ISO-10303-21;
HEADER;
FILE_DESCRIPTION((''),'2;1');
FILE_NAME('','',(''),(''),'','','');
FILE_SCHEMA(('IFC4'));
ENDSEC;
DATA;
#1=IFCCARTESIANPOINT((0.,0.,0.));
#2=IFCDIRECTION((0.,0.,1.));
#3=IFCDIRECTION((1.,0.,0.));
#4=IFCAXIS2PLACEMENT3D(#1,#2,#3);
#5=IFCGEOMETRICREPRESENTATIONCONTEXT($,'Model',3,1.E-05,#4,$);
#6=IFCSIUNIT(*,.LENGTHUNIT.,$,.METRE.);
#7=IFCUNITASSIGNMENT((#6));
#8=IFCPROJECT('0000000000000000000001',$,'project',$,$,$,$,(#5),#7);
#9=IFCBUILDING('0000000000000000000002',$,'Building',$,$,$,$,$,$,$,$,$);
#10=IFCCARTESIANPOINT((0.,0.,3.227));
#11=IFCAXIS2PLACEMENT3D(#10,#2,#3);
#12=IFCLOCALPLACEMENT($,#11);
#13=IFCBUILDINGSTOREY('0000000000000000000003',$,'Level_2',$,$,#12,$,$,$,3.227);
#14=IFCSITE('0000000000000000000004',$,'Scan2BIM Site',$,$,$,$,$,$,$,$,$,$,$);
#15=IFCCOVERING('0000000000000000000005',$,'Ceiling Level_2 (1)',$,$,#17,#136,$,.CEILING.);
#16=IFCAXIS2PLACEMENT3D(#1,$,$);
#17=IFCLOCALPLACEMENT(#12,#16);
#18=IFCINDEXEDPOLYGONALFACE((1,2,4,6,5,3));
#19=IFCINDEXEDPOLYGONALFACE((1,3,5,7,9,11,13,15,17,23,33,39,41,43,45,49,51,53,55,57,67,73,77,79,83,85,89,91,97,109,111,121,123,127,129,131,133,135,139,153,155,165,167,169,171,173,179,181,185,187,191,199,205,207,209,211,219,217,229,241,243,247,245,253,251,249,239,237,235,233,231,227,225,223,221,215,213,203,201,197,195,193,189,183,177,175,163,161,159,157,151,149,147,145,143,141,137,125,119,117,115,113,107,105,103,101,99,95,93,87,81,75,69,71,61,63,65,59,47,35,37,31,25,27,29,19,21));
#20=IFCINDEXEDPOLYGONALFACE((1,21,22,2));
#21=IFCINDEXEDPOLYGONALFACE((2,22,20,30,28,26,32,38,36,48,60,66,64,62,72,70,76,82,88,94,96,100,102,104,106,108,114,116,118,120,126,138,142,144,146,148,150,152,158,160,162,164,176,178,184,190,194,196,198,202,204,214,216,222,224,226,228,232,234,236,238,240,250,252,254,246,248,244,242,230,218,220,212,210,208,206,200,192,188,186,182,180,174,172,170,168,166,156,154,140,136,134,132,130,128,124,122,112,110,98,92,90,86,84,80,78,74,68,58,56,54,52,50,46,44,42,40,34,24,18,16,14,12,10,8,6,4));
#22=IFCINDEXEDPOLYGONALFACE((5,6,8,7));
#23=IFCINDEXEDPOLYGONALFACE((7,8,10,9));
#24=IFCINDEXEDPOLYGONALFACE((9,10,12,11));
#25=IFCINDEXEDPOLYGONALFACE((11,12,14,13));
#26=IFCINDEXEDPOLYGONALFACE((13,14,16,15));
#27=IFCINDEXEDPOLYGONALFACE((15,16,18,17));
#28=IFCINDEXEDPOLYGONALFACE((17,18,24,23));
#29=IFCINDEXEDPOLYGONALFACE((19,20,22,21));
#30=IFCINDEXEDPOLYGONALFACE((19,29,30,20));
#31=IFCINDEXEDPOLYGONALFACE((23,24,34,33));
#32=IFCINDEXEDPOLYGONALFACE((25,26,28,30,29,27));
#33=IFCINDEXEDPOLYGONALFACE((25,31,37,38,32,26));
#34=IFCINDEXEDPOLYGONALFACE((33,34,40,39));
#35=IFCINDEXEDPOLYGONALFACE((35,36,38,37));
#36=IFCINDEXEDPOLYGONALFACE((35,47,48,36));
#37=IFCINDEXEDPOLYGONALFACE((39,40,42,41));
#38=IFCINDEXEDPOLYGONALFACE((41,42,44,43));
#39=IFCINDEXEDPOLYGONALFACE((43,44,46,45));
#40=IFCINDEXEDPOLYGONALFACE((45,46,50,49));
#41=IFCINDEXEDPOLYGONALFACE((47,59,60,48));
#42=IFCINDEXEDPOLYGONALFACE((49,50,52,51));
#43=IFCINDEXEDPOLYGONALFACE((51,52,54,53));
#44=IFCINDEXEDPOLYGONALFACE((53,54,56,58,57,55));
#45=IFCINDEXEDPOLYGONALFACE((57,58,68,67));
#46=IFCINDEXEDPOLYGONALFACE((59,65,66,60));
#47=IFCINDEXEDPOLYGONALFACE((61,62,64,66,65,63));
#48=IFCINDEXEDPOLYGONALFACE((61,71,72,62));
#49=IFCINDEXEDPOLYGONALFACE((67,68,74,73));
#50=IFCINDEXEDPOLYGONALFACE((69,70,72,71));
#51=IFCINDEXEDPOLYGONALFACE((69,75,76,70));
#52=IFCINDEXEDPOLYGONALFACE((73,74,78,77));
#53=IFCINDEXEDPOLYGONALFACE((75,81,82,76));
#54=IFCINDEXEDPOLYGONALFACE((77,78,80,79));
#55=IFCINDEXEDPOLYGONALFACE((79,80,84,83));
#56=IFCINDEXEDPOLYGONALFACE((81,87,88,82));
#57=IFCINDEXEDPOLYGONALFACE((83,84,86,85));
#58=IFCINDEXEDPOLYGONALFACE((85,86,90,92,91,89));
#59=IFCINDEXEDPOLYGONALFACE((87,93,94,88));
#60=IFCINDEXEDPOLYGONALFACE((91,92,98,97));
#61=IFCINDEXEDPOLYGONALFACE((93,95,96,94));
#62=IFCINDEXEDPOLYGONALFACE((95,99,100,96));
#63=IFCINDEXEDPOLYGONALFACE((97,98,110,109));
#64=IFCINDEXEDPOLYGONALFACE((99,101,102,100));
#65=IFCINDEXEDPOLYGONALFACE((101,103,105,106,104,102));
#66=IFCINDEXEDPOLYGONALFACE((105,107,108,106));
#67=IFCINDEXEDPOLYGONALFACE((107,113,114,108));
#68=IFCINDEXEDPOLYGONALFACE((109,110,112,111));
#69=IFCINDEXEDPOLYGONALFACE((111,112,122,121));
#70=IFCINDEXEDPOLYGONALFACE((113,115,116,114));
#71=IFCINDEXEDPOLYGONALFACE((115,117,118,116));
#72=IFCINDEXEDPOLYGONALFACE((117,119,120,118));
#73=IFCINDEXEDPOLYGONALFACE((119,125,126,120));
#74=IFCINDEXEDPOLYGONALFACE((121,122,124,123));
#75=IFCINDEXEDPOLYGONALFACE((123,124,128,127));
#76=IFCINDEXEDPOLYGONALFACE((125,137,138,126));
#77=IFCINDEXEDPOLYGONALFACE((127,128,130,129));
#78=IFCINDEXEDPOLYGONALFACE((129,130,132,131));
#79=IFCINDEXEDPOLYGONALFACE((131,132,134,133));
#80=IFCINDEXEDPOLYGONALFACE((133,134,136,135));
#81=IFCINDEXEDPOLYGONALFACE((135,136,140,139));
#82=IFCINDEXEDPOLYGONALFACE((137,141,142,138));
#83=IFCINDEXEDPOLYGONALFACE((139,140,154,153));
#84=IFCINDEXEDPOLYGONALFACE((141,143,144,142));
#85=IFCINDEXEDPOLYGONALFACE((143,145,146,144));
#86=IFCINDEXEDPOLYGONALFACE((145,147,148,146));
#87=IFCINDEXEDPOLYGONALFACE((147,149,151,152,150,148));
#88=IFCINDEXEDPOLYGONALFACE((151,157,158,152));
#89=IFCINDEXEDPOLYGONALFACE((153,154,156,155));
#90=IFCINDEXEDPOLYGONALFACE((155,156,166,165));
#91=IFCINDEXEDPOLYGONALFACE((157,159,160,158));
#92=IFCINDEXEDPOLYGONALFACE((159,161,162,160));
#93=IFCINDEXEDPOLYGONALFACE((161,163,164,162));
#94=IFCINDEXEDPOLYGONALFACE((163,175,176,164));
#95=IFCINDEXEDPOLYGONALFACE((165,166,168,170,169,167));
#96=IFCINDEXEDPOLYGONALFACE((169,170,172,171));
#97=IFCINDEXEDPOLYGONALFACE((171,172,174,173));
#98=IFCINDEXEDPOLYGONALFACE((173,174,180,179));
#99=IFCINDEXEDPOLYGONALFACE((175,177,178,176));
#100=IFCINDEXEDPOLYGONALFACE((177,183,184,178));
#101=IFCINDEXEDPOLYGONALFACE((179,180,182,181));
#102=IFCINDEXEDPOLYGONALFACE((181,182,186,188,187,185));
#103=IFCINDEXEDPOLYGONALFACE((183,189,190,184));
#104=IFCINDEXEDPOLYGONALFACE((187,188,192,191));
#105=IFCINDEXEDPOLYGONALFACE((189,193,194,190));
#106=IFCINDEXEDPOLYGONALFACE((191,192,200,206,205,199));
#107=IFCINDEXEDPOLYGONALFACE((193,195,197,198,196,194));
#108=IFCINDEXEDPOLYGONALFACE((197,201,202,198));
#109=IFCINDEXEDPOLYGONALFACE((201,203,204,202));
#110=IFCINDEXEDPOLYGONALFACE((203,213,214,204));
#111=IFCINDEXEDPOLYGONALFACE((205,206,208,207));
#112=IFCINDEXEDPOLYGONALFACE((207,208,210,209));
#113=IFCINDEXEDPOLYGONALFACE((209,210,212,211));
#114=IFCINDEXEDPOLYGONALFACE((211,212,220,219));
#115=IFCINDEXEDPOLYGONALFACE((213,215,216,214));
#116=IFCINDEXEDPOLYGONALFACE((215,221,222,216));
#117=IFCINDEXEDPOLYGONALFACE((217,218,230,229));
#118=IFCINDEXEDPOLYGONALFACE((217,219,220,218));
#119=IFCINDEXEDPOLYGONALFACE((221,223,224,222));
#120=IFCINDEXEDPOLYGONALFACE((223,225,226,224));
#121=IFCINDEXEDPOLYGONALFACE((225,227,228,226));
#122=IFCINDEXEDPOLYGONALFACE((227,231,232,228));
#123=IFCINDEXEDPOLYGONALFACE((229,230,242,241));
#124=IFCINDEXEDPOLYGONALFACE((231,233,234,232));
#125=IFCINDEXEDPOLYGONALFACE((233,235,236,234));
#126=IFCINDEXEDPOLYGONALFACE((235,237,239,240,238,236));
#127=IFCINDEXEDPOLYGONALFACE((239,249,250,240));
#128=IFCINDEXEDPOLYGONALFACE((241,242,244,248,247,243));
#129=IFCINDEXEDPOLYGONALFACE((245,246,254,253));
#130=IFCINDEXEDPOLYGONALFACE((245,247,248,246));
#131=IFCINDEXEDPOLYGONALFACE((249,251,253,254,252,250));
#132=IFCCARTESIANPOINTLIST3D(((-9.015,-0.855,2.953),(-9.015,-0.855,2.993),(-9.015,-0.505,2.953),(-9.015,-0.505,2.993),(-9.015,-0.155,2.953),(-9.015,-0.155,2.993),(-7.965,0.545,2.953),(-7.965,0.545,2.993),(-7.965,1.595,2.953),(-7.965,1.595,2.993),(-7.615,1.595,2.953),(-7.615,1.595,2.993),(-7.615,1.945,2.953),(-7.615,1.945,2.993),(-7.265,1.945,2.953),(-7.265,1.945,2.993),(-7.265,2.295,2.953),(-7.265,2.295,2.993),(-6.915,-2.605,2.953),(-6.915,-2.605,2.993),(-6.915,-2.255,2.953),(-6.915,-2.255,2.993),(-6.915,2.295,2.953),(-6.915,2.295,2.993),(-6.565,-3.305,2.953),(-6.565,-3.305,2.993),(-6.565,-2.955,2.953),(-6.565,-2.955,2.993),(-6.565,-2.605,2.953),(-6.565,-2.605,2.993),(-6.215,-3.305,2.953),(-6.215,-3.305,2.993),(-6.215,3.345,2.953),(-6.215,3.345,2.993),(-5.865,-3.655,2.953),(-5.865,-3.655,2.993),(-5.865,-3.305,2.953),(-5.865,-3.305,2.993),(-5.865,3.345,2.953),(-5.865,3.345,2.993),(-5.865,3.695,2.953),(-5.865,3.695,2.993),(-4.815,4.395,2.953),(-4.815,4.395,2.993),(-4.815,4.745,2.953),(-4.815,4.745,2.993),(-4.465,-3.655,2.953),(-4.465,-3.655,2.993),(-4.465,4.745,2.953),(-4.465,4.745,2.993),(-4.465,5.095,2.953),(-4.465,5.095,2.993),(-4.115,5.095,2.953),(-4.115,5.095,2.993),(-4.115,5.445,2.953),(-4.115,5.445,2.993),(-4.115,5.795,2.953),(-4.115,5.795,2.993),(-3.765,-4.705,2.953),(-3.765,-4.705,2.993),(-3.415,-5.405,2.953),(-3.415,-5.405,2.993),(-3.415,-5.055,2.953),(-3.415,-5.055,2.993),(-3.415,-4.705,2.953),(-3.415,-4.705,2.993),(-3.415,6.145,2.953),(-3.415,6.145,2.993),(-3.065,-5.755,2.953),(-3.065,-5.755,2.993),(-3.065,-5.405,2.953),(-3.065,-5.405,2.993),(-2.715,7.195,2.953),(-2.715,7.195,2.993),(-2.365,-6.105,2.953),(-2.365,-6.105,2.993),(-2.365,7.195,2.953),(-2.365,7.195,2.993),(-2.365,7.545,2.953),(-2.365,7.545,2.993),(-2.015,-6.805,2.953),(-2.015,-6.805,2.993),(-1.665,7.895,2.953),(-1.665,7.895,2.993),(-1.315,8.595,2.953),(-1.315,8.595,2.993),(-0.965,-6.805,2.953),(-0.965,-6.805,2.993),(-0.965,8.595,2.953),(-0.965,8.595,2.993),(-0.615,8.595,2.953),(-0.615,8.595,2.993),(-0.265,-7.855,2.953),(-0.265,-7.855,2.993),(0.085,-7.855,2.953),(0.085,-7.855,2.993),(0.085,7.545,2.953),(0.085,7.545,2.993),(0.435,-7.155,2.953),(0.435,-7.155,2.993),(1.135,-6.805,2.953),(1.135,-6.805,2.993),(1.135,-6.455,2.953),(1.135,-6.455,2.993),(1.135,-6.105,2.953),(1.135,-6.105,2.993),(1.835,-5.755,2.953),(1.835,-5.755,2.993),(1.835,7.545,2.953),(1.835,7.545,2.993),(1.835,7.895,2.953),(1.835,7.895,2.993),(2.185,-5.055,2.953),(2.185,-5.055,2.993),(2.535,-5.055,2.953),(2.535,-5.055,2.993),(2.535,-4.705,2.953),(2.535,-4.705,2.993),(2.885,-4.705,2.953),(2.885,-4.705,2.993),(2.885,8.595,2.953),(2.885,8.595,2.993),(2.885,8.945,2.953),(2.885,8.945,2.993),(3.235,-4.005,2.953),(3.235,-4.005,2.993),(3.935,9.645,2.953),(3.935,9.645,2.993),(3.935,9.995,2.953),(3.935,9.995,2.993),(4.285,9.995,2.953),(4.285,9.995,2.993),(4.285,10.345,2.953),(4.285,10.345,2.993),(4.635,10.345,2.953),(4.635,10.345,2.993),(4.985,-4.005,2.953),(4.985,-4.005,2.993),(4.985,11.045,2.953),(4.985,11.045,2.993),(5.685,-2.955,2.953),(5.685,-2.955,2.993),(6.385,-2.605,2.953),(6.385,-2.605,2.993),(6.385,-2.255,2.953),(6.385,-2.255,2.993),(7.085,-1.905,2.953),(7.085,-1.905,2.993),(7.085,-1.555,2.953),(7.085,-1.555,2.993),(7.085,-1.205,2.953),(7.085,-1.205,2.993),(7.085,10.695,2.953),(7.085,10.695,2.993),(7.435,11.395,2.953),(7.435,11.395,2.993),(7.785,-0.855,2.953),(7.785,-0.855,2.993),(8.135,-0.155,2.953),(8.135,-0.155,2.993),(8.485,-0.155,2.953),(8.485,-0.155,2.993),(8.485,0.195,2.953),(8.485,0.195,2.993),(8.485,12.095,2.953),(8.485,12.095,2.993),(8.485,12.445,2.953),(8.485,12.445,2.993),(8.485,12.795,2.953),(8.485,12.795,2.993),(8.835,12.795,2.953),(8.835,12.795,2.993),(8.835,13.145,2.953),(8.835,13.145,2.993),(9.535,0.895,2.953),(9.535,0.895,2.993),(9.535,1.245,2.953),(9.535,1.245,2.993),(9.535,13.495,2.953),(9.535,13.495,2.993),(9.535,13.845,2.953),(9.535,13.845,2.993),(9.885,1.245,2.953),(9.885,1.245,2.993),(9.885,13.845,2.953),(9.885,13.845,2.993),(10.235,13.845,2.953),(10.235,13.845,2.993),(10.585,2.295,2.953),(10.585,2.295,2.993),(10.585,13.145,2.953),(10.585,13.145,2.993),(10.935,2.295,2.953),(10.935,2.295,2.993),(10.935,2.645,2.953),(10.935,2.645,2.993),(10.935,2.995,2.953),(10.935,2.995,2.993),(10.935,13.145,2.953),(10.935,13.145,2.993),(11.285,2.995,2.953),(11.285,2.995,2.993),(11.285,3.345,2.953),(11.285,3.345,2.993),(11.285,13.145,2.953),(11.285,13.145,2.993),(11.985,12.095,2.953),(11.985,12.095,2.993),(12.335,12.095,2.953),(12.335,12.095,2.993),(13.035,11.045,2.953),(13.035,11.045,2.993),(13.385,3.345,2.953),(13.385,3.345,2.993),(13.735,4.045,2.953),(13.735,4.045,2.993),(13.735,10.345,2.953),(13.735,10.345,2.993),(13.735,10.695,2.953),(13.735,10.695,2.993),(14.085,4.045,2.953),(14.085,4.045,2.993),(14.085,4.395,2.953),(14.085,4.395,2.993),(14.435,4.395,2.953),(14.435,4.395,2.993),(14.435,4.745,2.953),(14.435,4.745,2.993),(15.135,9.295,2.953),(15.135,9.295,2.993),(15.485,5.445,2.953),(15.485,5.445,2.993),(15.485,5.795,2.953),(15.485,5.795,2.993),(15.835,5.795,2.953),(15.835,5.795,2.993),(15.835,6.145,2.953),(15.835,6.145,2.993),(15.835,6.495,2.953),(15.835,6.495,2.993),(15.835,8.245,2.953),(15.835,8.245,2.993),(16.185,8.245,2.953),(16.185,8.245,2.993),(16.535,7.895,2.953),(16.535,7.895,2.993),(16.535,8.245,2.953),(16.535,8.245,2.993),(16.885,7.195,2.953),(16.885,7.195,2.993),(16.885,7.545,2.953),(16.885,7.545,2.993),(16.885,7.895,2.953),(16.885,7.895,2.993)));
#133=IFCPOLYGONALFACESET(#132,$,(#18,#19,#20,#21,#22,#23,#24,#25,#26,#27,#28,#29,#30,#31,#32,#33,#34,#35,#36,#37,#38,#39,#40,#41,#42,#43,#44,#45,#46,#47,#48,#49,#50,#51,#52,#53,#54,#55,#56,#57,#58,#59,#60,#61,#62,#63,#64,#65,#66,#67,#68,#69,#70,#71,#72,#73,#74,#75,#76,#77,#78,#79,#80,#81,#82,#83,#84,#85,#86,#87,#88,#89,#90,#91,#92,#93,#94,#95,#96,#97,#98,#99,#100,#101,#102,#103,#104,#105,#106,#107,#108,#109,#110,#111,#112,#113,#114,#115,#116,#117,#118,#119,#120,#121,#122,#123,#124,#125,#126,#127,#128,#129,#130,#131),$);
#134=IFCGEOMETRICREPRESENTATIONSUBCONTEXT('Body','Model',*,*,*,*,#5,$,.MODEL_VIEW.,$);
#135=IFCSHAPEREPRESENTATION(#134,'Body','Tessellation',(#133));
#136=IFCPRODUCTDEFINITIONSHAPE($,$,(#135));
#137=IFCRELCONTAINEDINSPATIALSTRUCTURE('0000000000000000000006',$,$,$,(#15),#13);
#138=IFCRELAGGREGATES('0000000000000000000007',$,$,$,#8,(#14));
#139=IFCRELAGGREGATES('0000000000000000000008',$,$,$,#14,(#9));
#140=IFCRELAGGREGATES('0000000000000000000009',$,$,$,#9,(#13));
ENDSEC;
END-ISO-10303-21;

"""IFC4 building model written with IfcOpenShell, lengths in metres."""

from ifc_helpers import new_model, si_unit, frame, origin, origin_with_axes, place, context, subcontext, project, spatial, polyline, outline, extrude, element, save


model = new_model("IFC4")

# Units and contexts
model_context = context("Model", 3, precision=1e-05, world=origin_with_axes())
body_context = subcontext(model_context, "Body", "Model", "MODEL_VIEW")
ifc_project = project(units=[si_unit("LENGTHUNIT", "METRE")], contexts=[model_context])

# Site, building, storey
site = spatial("IfcSite", under=ifc_project, Name="Scan2BIM Site")
building = spatial("IfcBuilding", under=site, Name="Building")
storey_placement = place(None, frame((0.0, 0.0, 3.227), z_axis=(0.0, 0.0, 1.0), x_axis=(1.0, 0.0, 0.0)))
storey = spatial("IfcBuildingStorey", under=building, at=storey_placement, Name="Level_2", Elevation=3.227)

# Covering
covering_placement = place(storey_placement, frame((0.0, 0.0, 2.953), z_axis=(0.0, 0.0, 1.0), x_axis=(1.0, 0.0, 0.0)))
element("IfcCovering", 1, at=covering_placement, inside=storey, Name="Ceiling Level_2 (1)", PredefinedType="CEILING", context=body_context, shape_type="SweptSolid", body=[
    extrude(outline(polyline([(-0.265, -7.855), (0.085, -7.855), (0.435, -7.155), (1.135, -6.805), (1.135, -6.455), (1.135, -6.105), (1.835, -5.755), (2.185, -5.055), (2.535, -5.055), (2.535, -4.705), (2.885, -4.705), (3.235, -4.005), (4.985, -4.005), (5.685, -2.955), (6.385, -2.605), (6.385, -2.255), (7.085, -1.905), (7.085, -1.555), (7.085, -1.205), (7.785, -0.855), (8.135, -0.155), (8.485, -0.155), (8.485, 0.195), (9.535, 0.895), (9.535, 1.245), (9.885, 1.245), (10.585, 2.295), (10.935, 2.295), (10.935, 2.645), (10.935, 2.995), (11.285, 2.995), (11.285, 3.345), (13.385, 3.345), (13.735, 4.045), (14.085, 4.045), (14.085, 4.395), (14.435, 4.395), (14.435, 4.745), (15.485, 5.445), (15.485, 5.795), (15.835, 5.795), (15.835, 6.145), (15.835, 6.495), (16.885, 7.195), (16.885, 7.545), (16.885, 7.895), (16.535, 7.895), (16.535, 8.245), (16.185, 8.245), (15.835, 8.245), (15.135, 9.295), (13.735, 10.345), (13.735, 10.695), (13.035, 11.045), (12.335, 12.095), (11.985, 12.095), (11.285, 13.145), (10.935, 13.145), (10.585, 13.145), (10.235, 13.845), (9.885, 13.845), (9.535, 13.845), (9.535, 13.495), (8.835, 13.145), (8.835, 12.795), (8.485, 12.795), (8.485, 12.445), (8.485, 12.095), (7.435, 11.395), (7.085, 10.695), (4.985, 11.045), (4.635, 10.345), (4.285, 10.345), (4.285, 9.995), (3.935, 9.995), (3.935, 9.645), (2.885, 8.945), (2.885, 8.595), (1.835, 7.895), (1.835, 7.545), (0.085, 7.545), (-0.615, 8.595), (-0.965, 8.595), (-1.315, 8.595), (-1.665, 7.895), (-2.365, 7.545), (-2.365, 7.195), (-2.715, 7.195), (-3.415, 6.145), (-4.115, 5.795), (-4.115, 5.445), (-4.115, 5.095), (-4.465, 5.095), (-4.465, 4.745), (-4.815, 4.745), (-4.815, 4.395), (-5.865, 3.695), (-5.865, 3.345), (-6.215, 3.345), (-6.915, 2.295), (-7.265, 2.295), (-7.265, 1.945), (-7.615, 1.945), (-7.615, 1.595), (-7.965, 1.595), (-7.965, 0.545), (-9.015, -0.155), (-9.015, -0.505), (-9.015, -0.855), (-6.915, -2.255), (-6.915, -2.605), (-6.565, -2.605), (-6.565, -2.955), (-6.565, -3.305), (-6.215, -3.305), (-5.865, -3.305), (-5.865, -3.655), (-4.465, -3.655), (-3.765, -4.705), (-3.415, -4.705), (-3.415, -5.055), (-3.415, -5.405), (-3.065, -5.405), (-3.065, -5.755), (-2.365, -6.105), (-2.015, -6.805), (-0.965, -6.805), (-0.265, -7.855)])), origin(), (0.0, 0.0, 1.0), 0.04),
])

save(model, "model.ifc")
